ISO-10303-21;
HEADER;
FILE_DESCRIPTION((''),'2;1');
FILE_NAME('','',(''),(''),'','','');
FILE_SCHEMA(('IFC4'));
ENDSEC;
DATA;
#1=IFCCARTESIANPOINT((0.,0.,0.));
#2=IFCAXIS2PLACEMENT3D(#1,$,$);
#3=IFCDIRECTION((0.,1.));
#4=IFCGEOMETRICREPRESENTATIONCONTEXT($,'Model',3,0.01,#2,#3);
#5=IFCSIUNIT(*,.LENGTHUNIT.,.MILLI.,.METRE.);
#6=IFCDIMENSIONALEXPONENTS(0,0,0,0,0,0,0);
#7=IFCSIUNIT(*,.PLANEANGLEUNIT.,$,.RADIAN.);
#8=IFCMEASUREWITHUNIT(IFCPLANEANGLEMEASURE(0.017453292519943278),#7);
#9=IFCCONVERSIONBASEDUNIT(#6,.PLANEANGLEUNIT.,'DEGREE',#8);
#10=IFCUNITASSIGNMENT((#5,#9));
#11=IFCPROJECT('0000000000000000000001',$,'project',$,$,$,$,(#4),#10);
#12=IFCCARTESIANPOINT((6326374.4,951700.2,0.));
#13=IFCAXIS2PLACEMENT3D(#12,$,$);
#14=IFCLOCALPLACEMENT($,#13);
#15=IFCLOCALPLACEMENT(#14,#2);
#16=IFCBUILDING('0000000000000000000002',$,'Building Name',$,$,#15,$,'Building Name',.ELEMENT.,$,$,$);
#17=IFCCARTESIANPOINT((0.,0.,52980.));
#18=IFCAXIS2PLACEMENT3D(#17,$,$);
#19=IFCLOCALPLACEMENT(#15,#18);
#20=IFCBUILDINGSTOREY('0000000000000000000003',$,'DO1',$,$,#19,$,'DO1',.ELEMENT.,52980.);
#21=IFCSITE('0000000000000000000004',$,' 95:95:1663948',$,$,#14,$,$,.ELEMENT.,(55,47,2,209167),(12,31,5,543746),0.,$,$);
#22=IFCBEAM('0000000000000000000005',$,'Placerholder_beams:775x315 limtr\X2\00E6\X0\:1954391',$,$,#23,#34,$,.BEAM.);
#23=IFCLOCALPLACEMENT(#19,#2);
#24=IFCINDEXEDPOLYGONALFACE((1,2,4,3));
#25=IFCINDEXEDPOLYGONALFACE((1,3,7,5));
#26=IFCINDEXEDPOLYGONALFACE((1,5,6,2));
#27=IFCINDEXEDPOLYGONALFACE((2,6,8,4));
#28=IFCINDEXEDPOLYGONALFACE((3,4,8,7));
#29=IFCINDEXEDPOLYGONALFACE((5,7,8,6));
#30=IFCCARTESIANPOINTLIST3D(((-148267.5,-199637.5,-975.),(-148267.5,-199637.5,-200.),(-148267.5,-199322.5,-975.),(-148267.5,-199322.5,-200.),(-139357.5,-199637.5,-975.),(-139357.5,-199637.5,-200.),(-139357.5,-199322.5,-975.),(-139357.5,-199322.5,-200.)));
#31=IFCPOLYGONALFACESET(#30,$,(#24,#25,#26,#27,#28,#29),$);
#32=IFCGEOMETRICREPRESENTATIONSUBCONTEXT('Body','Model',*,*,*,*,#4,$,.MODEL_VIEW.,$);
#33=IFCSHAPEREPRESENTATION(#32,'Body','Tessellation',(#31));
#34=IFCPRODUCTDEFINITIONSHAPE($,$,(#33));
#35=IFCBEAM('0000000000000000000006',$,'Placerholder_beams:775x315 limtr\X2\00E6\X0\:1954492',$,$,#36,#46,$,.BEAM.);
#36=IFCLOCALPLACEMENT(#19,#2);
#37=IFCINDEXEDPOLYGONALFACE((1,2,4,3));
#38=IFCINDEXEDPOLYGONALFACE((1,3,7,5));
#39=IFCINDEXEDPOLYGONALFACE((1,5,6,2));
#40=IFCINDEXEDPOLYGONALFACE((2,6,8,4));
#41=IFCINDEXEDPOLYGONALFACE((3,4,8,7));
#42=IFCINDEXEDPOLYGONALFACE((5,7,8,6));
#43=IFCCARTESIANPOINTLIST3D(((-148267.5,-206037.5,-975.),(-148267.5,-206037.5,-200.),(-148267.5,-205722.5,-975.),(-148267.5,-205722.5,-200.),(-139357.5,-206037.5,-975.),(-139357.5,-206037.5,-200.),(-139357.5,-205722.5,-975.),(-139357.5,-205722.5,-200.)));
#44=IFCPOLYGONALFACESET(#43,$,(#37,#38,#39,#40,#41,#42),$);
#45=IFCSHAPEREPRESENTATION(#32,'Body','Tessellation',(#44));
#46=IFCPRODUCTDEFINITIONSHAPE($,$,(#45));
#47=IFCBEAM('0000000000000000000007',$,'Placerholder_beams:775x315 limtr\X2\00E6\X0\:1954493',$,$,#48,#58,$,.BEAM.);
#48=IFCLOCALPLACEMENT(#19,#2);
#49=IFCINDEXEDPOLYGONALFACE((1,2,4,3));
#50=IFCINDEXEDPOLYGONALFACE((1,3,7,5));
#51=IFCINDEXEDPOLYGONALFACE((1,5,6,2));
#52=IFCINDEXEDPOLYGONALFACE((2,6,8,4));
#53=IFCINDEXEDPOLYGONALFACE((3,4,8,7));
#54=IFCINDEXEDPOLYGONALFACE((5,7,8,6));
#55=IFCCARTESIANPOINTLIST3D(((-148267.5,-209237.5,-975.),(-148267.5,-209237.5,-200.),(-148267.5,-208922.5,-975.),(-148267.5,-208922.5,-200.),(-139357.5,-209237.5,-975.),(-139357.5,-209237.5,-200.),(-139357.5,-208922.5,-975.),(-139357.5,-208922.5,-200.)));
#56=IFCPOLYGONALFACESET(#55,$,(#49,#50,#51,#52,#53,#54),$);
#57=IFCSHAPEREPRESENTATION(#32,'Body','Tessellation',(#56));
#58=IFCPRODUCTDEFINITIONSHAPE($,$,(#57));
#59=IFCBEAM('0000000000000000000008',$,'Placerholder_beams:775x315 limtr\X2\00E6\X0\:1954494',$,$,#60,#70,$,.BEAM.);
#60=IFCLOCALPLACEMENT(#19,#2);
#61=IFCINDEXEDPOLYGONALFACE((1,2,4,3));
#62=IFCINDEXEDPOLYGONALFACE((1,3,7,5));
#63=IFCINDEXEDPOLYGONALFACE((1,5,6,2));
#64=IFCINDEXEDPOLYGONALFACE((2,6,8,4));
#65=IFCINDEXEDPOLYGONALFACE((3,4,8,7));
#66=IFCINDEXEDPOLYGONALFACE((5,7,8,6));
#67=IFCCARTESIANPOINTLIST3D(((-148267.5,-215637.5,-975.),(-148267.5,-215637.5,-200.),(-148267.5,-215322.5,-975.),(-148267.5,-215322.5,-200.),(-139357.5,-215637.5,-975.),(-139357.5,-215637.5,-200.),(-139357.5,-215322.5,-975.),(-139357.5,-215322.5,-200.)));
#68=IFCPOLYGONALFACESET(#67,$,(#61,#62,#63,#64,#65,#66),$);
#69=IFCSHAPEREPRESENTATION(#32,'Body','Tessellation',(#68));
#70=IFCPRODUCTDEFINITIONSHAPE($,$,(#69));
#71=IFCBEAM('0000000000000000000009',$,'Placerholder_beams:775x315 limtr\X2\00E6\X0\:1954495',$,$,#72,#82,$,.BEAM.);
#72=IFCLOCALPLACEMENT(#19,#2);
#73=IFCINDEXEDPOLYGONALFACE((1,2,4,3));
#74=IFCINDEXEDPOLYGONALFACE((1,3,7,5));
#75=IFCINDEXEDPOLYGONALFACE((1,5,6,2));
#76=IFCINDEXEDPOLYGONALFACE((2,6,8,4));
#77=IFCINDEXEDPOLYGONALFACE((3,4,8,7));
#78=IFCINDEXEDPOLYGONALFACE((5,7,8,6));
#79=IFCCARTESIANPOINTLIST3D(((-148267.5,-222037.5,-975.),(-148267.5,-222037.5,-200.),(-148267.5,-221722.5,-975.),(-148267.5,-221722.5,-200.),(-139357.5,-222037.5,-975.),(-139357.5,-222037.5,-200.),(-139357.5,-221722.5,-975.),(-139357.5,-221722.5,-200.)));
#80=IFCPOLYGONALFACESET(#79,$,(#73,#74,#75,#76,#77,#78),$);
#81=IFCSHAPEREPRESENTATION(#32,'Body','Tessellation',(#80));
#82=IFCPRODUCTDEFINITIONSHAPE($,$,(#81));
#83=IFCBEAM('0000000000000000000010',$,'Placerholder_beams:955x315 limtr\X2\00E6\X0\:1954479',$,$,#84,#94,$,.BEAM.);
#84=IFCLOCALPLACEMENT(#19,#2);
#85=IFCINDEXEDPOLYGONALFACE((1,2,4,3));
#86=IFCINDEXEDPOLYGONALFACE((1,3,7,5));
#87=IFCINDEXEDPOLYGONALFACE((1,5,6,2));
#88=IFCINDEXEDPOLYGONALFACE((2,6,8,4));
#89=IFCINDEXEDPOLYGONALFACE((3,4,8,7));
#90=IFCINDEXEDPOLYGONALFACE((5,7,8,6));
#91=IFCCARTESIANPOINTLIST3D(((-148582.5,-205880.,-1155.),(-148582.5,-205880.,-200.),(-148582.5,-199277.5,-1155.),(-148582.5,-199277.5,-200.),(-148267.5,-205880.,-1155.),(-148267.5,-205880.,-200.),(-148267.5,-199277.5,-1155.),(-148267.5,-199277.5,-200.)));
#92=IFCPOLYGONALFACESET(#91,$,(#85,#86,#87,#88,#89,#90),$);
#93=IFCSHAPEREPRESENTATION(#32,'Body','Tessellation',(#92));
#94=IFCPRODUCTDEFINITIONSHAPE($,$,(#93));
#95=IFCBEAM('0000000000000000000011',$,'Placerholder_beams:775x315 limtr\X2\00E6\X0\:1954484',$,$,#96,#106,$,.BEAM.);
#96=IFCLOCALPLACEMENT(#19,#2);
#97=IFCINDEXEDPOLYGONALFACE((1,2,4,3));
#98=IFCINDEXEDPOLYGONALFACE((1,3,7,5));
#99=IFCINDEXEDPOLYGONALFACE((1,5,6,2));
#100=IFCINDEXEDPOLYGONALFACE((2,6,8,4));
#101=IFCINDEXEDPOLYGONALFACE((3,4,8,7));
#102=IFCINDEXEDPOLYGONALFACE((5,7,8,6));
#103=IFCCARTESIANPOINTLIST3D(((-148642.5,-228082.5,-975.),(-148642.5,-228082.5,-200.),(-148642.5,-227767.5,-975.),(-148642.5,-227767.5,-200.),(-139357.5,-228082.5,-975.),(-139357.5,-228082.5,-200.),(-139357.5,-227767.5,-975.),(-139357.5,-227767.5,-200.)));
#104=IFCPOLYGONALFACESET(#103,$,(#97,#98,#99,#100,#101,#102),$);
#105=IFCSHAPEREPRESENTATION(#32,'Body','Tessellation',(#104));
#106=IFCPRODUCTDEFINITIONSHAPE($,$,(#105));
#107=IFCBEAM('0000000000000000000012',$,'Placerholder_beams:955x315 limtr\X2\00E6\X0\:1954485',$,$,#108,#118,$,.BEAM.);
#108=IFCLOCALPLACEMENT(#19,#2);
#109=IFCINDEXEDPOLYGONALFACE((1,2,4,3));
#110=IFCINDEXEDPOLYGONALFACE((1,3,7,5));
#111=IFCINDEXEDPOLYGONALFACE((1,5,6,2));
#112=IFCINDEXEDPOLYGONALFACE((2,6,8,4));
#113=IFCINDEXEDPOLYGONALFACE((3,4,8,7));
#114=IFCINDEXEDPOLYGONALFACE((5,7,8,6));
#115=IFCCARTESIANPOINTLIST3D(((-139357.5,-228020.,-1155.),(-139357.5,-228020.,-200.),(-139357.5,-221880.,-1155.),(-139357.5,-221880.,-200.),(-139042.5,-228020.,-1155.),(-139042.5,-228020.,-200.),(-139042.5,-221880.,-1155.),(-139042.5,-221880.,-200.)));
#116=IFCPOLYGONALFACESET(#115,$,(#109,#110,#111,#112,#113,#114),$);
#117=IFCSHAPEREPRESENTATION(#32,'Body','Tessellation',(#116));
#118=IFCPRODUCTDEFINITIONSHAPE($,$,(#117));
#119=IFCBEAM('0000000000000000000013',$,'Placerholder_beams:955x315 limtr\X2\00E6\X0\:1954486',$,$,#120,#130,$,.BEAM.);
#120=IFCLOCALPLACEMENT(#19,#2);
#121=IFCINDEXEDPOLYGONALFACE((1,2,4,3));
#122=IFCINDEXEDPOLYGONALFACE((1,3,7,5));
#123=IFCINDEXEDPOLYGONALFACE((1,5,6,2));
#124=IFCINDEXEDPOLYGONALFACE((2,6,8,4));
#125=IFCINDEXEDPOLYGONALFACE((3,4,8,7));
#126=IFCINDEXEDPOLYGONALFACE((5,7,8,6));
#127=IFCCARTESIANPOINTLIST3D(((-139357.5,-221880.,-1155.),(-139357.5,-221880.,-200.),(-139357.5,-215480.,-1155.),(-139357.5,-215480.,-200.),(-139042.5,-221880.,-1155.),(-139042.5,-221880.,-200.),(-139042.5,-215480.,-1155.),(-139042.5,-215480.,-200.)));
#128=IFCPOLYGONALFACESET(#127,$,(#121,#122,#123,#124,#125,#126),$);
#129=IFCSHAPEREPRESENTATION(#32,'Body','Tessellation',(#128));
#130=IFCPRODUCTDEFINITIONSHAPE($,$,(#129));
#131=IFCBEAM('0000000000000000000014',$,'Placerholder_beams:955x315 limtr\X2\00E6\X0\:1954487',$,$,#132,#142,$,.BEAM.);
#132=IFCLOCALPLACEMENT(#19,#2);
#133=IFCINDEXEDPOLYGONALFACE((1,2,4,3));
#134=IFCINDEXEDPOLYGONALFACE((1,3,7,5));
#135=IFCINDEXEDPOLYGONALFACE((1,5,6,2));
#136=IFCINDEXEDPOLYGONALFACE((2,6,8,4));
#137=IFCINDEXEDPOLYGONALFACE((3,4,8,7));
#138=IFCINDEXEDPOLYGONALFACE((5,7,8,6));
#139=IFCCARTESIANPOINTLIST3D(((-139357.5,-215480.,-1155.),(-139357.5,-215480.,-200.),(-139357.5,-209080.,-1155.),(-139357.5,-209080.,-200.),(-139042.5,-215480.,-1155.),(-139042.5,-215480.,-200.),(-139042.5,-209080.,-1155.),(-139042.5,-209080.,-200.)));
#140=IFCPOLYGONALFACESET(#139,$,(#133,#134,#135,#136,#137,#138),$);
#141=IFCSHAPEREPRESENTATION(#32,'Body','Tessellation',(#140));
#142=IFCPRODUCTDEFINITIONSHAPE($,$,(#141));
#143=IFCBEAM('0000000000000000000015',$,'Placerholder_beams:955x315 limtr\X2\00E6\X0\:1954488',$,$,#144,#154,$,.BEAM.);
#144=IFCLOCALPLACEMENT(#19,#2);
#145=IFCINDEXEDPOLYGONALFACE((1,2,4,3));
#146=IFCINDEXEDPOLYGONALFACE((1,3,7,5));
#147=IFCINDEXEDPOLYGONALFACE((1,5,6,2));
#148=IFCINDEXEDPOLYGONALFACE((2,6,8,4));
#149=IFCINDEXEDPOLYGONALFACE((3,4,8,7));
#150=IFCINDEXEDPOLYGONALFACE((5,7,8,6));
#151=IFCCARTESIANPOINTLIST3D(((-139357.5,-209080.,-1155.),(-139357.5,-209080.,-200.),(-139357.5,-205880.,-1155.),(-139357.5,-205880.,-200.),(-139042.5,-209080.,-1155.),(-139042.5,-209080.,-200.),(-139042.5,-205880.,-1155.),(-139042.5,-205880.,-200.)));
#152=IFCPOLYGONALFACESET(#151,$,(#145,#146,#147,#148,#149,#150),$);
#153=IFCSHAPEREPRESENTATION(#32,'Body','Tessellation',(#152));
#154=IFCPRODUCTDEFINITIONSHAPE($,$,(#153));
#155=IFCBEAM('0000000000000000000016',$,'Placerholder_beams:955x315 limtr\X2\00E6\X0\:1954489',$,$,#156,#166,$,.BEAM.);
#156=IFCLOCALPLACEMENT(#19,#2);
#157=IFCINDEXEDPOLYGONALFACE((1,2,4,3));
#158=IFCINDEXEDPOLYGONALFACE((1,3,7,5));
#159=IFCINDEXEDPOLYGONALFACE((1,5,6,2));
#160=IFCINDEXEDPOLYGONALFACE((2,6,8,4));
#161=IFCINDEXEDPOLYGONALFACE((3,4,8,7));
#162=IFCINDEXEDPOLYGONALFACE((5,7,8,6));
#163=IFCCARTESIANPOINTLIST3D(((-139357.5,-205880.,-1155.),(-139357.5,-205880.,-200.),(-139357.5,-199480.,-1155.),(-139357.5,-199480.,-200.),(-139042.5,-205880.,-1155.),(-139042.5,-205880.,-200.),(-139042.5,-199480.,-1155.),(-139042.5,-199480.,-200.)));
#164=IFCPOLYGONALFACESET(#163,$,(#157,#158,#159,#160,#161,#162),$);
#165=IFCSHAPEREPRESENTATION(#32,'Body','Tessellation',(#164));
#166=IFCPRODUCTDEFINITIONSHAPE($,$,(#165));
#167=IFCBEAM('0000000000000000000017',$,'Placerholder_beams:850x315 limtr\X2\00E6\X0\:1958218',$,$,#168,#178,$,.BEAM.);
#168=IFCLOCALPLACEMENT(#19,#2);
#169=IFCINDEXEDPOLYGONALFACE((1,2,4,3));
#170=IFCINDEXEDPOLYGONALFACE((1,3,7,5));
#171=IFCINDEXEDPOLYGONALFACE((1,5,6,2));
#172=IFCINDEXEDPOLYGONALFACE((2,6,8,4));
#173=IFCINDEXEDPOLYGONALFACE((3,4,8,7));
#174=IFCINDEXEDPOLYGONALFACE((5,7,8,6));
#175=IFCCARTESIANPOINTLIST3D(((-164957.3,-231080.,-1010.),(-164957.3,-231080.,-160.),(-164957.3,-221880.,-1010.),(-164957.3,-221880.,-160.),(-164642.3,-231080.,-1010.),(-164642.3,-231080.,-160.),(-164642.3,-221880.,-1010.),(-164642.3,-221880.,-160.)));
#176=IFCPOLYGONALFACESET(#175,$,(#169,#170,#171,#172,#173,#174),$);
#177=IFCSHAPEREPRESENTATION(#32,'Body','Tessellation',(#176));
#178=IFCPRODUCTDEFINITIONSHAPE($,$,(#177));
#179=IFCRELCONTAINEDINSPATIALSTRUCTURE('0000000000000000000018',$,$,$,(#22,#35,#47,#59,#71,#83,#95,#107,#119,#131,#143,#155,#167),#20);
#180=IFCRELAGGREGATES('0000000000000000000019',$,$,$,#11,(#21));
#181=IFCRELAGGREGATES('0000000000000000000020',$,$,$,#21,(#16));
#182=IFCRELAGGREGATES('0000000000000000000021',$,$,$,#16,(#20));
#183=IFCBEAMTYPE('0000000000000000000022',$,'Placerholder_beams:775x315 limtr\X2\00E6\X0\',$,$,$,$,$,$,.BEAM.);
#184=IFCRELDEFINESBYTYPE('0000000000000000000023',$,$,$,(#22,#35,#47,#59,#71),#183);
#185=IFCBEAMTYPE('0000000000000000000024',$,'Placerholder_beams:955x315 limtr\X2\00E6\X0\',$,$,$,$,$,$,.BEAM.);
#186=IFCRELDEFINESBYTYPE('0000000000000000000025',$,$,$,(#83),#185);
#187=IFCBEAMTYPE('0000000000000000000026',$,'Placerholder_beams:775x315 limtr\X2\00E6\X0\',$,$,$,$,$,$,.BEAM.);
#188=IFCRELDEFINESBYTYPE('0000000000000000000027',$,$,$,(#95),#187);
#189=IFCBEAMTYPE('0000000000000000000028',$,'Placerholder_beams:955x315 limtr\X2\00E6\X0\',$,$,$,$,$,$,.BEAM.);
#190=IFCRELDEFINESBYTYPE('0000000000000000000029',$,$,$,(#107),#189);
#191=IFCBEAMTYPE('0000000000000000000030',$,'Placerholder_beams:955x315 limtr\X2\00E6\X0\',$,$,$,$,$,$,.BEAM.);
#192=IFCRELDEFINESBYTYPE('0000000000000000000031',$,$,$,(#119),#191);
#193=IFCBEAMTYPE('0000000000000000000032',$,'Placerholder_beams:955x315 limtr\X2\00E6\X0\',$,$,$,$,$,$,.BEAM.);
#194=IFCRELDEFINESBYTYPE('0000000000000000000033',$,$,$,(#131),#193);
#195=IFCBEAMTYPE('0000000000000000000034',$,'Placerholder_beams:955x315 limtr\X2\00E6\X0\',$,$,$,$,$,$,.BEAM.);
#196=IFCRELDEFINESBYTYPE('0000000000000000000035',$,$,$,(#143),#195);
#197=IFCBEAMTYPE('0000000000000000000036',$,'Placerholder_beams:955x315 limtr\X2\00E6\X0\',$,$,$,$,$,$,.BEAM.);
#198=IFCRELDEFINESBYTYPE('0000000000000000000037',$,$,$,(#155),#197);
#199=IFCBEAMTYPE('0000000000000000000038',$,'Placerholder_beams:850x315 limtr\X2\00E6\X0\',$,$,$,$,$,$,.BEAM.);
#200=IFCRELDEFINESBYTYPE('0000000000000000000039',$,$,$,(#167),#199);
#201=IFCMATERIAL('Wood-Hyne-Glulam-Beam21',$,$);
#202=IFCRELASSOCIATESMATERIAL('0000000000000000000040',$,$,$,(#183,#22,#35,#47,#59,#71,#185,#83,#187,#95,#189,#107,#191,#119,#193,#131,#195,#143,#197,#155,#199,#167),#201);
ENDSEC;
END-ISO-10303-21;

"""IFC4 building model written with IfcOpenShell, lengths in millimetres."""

from ifc_helpers import new_model, entity, si_unit, converted_unit, direction, frame, origin, place, context, subcontext, project, spatial, indexed_curve, outline, extrude, source, transform, mapped, material, type_object, type_shapes, element, save


model = new_model("IFC4")

# Units and contexts
model_context = context("Model", 3, precision=0.01, world=origin(), true_north=direction((0.0, 1.0)))
body_context = subcontext(model_context, "Body", "Model", "MODEL_VIEW")
ifc_project = project(units=[si_unit("LENGTHUNIT", "METRE", prefix="MILLI"), converted_unit("PLANEANGLEUNIT", "DEGREE", entity("IfcPlaneAngleMeasure", 0.017453292519943278), si_unit("PLANEANGLEUNIT", "RADIAN"), dimensions=[0, 0, 0, 0, 0, 0, 0])], contexts=[model_context])

# Site, building, storey
site_placement = place(None, frame((6326374.4, 951700.2, 0.0)))
site = spatial("IfcSite", under=ifc_project, at=site_placement, Name=" 95:95:1663948", CompositionType="ELEMENT", RefLatitude=(55, 47, 2, 209167), RefLongitude=(12, 31, 5, 543746), RefElevation=0.0)
building_placement = place(site_placement, origin())
building = spatial("IfcBuilding", under=site, at=building_placement, Name="Building Name", LongName="Building Name", CompositionType="ELEMENT")
storey_placement = place(building_placement, frame((0.0, 0.0, 52980.0)))
storey = spatial("IfcBuildingStorey", under=building, at=storey_placement, Name="DO1", LongName="DO1", CompositionType="ELEMENT", Elevation=52980.0)

# Beams
ifc_material = material(Name="Wood-Hyne-Glulam-Beam21")
beam_type_1 = type_object("IfcBeamType", Name="Placerholder_beams:775x315 limtræ", PredefinedType="BEAM", material=ifc_material)
shared_shape_1 = source(origin(), body_context, "Body", "SweptSolid", [
    extrude(outline(indexed_curve([(-4455.0, -157.5), (4455.0, -157.5), (4455.0, 157.5), (-4455.0, 157.5), (-4455.0, -157.5)], self_intersect=False)), frame((0.0, 0.0, -387.5)), (0.0, 0.0, 1.0), 775.0),
])
type_shapes(beam_type_1, [shared_shape_1])
for number, where, name in (
    (1, (-143812.5, -199480.0, -587.5), "Placerholder_beams:775x315 limtræ:1954391"),
    (2, (-143812.5, -205880.0, -587.5), "Placerholder_beams:775x315 limtræ:1954492"),
    (3, (-143812.5, -209080.0, -587.5), "Placerholder_beams:775x315 limtræ:1954493"),
    (4, (-143812.5, -215480.0, -587.5), "Placerholder_beams:775x315 limtræ:1954494"),
    (5, (-143812.5, -221880.0, -587.5), "Placerholder_beams:775x315 limtræ:1954495"),
):
    element("IfcBeam", number, at=place(storey_placement, frame(where)), inside=storey, type_object=beam_type_1, material=ifc_material, Name=name, PredefinedType="BEAM", context=body_context, shape_type="MappedRepresentation", body=[
        mapped(shared_shape_1, transform((0.0, 0.0, 0.0), scale=1.0)),
    ])
beam_type_2 = type_object("IfcBeamType", Name="Placerholder_beams:955x315 limtræ", PredefinedType="BEAM", material=ifc_material)
shared_shape_2 = source(origin(), body_context, "Body", "SweptSolid", [
    extrude(outline(indexed_curve([(-3301.2, -157.5), (3301.2, -157.5), (3301.2, 157.5), (-3301.2, 157.5), (-3301.2, -157.5)], self_intersect=False)), frame((-1701.2, 0.0, -477.5)), (0.0, 0.0, 1.0), 955.0),
])
type_shapes(beam_type_2, [shared_shape_2])
beam_1_placement = place(storey_placement, frame((-148425.0, -204280.0, -677.5), z_axis=(0.0, 0.0, 1.0), x_axis=(0.0, -1.0, 0.0)))
element("IfcBeam", 6, at=beam_1_placement, inside=storey, type_object=beam_type_2, material=ifc_material, Name="Placerholder_beams:955x315 limtræ:1954479", PredefinedType="BEAM", context=body_context, shape_type="MappedRepresentation", body=[
    mapped(shared_shape_2, transform((0.0, 0.0, 0.0), scale=1.0)),
])
beam_type_3 = type_object("IfcBeamType", Name="Placerholder_beams:775x315 limtræ", PredefinedType="BEAM", material=ifc_material)
shared_shape_3 = source(origin(), body_context, "Body", "SweptSolid", [
    extrude(outline(indexed_curve([(-4642.5, -157.5), (4642.5, -157.5), (4642.5, 157.5), (-4642.5, 157.5), (-4642.5, -157.5)], self_intersect=False)), frame((1600.0, 0.0, -387.5)), (0.0, 0.0, 1.0), 775.0),
])
type_shapes(beam_type_3, [shared_shape_3])
beam_2_placement = place(storey_placement, frame((-145600.0, -227925.0, -587.5)))
element("IfcBeam", 7, at=beam_2_placement, inside=storey, type_object=beam_type_3, material=ifc_material, Name="Placerholder_beams:775x315 limtræ:1954484", PredefinedType="BEAM", context=body_context, shape_type="MappedRepresentation", body=[
    mapped(shared_shape_3, transform((0.0, 0.0, 0.0), scale=1.0)),
])
beam_type_4 = type_object("IfcBeamType", Name="Placerholder_beams:955x315 limtræ", PredefinedType="BEAM", material=ifc_material)
shared_shape_4 = source(origin(), body_context, "Body", "SweptSolid", [
    extrude(outline(indexed_curve([(-3070.0, -157.5), (3070.0, -157.5), (3070.0, 157.5), (-3070.0, 157.5), (-3070.0, -157.5)], self_intersect=False)), frame((-47.5, 0.0, -477.5)), (0.0, 0.0, 1.0), 955.0),
])
type_shapes(beam_type_4, [shared_shape_4])
beam_3_placement = place(storey_placement, frame((-139200.0, -224902.5, -677.5), z_axis=(0.0, 0.0, 1.0), x_axis=(0.0, 1.0, 0.0)))
element("IfcBeam", 8, at=beam_3_placement, inside=storey, type_object=beam_type_4, material=ifc_material, Name="Placerholder_beams:955x315 limtræ:1954485", PredefinedType="BEAM", context=body_context, shape_type="MappedRepresentation", body=[
    mapped(shared_shape_4, transform((0.0, 0.0, 0.0), scale=1.0)),
])
beam_type_5 = type_object("IfcBeamType", Name="Placerholder_beams:955x315 limtræ", PredefinedType="BEAM", material=ifc_material)
shared_shape_5 = source(origin(), body_context, "Body", "SweptSolid", [
    extrude(outline(indexed_curve([(-3200.0, -157.5), (3200.0, -157.5), (3200.0, 157.5), (-3200.0, 157.5), (-3200.0, -157.5)], self_intersect=False)), frame((0.0, 0.0, -477.5)), (0.0, 0.0, 1.0), 955.0),
])
type_shapes(beam_type_5, [shared_shape_5])
beam_4_placement = place(storey_placement, frame((-139200.0, -218680.0, -677.5), z_axis=(0.0, 0.0, 1.0), x_axis=(0.0, 1.0, 0.0)))
element("IfcBeam", 9, at=beam_4_placement, inside=storey, type_object=beam_type_5, material=ifc_material, Name="Placerholder_beams:955x315 limtræ:1954486", PredefinedType="BEAM", context=body_context, shape_type="MappedRepresentation", body=[
    mapped(shared_shape_5, transform((0.0, 0.0, 0.0), scale=1.0)),
])
beam_type_6 = type_object("IfcBeamType", Name="Placerholder_beams:955x315 limtræ", PredefinedType="BEAM", material=ifc_material)
shared_shape_6 = source(origin(), body_context, "Body", "SweptSolid", [
    extrude(outline(indexed_curve([(-3200.0, -157.5), (3200.0, -157.5), (3200.0, 157.5), (-3200.0, 157.5), (-3200.0, -157.5)], self_intersect=False)), frame((0.0, 0.0, -477.5)), (0.0, 0.0, 1.0), 955.0),
])
type_shapes(beam_type_6, [shared_shape_6])
beam_5_placement = place(storey_placement, frame((-139200.0, -212280.0, -677.5), z_axis=(0.0, 0.0, 1.0), x_axis=(0.0, 1.0, 0.0)))
element("IfcBeam", 10, at=beam_5_placement, inside=storey, type_object=beam_type_6, material=ifc_material, Name="Placerholder_beams:955x315 limtræ:1954487", PredefinedType="BEAM", context=body_context, shape_type="MappedRepresentation", body=[
    mapped(shared_shape_6, transform((0.0, 0.0, 0.0), scale=1.0)),
])
beam_type_7 = type_object("IfcBeamType", Name="Placerholder_beams:955x315 limtræ", PredefinedType="BEAM", material=ifc_material)
shared_shape_7 = source(origin(), body_context, "Body", "SweptSolid", [
    extrude(outline(indexed_curve([(-1600.0, -157.5), (1600.0, -157.5), (1600.0, 157.5), (-1600.0, 157.5), (-1600.0, -157.5)], self_intersect=False)), frame((0.0, 0.0, -477.5)), (0.0, 0.0, 1.0), 955.0),
])
type_shapes(beam_type_7, [shared_shape_7])
beam_6_placement = place(storey_placement, frame((-139200.0, -207480.0, -677.5), z_axis=(0.0, 0.0, 1.0), x_axis=(0.0, 1.0, 0.0)))
element("IfcBeam", 11, at=beam_6_placement, inside=storey, type_object=beam_type_7, material=ifc_material, Name="Placerholder_beams:955x315 limtræ:1954488", PredefinedType="BEAM", context=body_context, shape_type="MappedRepresentation", body=[
    mapped(shared_shape_7, transform((0.0, 0.0, 0.0), scale=1.0)),
])
beam_type_8 = type_object("IfcBeamType", Name="Placerholder_beams:955x315 limtræ", PredefinedType="BEAM", material=ifc_material)
shared_shape_8 = source(origin(), body_context, "Body", "SweptSolid", [
    extrude(outline(indexed_curve([(-3200.0, -157.5), (3200.0, -157.5), (3200.0, 157.5), (-3200.0, 157.5), (-3200.0, -157.5)], self_intersect=False)), frame((1600.0, 0.0, -477.5)), (0.0, 0.0, 1.0), 955.0),
])
type_shapes(beam_type_8, [shared_shape_8])
beam_7_placement = place(storey_placement, frame((-139200.0, -204280.0, -677.5), z_axis=(0.0, 0.0, 1.0), x_axis=(0.0, 1.0, 0.0)))
element("IfcBeam", 12, at=beam_7_placement, inside=storey, type_object=beam_type_8, material=ifc_material, Name="Placerholder_beams:955x315 limtræ:1954489", PredefinedType="BEAM", context=body_context, shape_type="MappedRepresentation", body=[
    mapped(shared_shape_8, transform((0.0, 0.0, 0.0), scale=1.0)),
])
beam_type_9 = type_object("IfcBeamType", Name="Placerholder_beams:850x315 limtræ", PredefinedType="BEAM", material=ifc_material)
shared_shape_9 = source(origin(), body_context, "Body", "SweptSolid", [
    extrude(outline(indexed_curve([(-4600.0, -157.5), (4600.0, -157.5), (4600.0, 157.5), (-4600.0, 157.5), (-4600.0, -157.5)], self_intersect=False)), frame((0.0, 0.0, -425.0)), (0.0, 0.0, 1.0), 850.0),
])
type_shapes(beam_type_9, [shared_shape_9])
beam_8_placement = place(storey_placement, frame((-164799.8, -226480.0, -585.0), z_axis=(0.0, 0.0, 1.0), x_axis=(0.0, 1.0, 0.0)))
element("IfcBeam", 13, at=beam_8_placement, inside=storey, type_object=beam_type_9, material=ifc_material, Name="Placerholder_beams:850x315 limtræ:1958218", PredefinedType="BEAM", context=body_context, shape_type="MappedRepresentation", body=[
    mapped(shared_shape_9, transform((0.0, 0.0, 0.0), scale=1.0)),
])

save(model, "model.ifc")
